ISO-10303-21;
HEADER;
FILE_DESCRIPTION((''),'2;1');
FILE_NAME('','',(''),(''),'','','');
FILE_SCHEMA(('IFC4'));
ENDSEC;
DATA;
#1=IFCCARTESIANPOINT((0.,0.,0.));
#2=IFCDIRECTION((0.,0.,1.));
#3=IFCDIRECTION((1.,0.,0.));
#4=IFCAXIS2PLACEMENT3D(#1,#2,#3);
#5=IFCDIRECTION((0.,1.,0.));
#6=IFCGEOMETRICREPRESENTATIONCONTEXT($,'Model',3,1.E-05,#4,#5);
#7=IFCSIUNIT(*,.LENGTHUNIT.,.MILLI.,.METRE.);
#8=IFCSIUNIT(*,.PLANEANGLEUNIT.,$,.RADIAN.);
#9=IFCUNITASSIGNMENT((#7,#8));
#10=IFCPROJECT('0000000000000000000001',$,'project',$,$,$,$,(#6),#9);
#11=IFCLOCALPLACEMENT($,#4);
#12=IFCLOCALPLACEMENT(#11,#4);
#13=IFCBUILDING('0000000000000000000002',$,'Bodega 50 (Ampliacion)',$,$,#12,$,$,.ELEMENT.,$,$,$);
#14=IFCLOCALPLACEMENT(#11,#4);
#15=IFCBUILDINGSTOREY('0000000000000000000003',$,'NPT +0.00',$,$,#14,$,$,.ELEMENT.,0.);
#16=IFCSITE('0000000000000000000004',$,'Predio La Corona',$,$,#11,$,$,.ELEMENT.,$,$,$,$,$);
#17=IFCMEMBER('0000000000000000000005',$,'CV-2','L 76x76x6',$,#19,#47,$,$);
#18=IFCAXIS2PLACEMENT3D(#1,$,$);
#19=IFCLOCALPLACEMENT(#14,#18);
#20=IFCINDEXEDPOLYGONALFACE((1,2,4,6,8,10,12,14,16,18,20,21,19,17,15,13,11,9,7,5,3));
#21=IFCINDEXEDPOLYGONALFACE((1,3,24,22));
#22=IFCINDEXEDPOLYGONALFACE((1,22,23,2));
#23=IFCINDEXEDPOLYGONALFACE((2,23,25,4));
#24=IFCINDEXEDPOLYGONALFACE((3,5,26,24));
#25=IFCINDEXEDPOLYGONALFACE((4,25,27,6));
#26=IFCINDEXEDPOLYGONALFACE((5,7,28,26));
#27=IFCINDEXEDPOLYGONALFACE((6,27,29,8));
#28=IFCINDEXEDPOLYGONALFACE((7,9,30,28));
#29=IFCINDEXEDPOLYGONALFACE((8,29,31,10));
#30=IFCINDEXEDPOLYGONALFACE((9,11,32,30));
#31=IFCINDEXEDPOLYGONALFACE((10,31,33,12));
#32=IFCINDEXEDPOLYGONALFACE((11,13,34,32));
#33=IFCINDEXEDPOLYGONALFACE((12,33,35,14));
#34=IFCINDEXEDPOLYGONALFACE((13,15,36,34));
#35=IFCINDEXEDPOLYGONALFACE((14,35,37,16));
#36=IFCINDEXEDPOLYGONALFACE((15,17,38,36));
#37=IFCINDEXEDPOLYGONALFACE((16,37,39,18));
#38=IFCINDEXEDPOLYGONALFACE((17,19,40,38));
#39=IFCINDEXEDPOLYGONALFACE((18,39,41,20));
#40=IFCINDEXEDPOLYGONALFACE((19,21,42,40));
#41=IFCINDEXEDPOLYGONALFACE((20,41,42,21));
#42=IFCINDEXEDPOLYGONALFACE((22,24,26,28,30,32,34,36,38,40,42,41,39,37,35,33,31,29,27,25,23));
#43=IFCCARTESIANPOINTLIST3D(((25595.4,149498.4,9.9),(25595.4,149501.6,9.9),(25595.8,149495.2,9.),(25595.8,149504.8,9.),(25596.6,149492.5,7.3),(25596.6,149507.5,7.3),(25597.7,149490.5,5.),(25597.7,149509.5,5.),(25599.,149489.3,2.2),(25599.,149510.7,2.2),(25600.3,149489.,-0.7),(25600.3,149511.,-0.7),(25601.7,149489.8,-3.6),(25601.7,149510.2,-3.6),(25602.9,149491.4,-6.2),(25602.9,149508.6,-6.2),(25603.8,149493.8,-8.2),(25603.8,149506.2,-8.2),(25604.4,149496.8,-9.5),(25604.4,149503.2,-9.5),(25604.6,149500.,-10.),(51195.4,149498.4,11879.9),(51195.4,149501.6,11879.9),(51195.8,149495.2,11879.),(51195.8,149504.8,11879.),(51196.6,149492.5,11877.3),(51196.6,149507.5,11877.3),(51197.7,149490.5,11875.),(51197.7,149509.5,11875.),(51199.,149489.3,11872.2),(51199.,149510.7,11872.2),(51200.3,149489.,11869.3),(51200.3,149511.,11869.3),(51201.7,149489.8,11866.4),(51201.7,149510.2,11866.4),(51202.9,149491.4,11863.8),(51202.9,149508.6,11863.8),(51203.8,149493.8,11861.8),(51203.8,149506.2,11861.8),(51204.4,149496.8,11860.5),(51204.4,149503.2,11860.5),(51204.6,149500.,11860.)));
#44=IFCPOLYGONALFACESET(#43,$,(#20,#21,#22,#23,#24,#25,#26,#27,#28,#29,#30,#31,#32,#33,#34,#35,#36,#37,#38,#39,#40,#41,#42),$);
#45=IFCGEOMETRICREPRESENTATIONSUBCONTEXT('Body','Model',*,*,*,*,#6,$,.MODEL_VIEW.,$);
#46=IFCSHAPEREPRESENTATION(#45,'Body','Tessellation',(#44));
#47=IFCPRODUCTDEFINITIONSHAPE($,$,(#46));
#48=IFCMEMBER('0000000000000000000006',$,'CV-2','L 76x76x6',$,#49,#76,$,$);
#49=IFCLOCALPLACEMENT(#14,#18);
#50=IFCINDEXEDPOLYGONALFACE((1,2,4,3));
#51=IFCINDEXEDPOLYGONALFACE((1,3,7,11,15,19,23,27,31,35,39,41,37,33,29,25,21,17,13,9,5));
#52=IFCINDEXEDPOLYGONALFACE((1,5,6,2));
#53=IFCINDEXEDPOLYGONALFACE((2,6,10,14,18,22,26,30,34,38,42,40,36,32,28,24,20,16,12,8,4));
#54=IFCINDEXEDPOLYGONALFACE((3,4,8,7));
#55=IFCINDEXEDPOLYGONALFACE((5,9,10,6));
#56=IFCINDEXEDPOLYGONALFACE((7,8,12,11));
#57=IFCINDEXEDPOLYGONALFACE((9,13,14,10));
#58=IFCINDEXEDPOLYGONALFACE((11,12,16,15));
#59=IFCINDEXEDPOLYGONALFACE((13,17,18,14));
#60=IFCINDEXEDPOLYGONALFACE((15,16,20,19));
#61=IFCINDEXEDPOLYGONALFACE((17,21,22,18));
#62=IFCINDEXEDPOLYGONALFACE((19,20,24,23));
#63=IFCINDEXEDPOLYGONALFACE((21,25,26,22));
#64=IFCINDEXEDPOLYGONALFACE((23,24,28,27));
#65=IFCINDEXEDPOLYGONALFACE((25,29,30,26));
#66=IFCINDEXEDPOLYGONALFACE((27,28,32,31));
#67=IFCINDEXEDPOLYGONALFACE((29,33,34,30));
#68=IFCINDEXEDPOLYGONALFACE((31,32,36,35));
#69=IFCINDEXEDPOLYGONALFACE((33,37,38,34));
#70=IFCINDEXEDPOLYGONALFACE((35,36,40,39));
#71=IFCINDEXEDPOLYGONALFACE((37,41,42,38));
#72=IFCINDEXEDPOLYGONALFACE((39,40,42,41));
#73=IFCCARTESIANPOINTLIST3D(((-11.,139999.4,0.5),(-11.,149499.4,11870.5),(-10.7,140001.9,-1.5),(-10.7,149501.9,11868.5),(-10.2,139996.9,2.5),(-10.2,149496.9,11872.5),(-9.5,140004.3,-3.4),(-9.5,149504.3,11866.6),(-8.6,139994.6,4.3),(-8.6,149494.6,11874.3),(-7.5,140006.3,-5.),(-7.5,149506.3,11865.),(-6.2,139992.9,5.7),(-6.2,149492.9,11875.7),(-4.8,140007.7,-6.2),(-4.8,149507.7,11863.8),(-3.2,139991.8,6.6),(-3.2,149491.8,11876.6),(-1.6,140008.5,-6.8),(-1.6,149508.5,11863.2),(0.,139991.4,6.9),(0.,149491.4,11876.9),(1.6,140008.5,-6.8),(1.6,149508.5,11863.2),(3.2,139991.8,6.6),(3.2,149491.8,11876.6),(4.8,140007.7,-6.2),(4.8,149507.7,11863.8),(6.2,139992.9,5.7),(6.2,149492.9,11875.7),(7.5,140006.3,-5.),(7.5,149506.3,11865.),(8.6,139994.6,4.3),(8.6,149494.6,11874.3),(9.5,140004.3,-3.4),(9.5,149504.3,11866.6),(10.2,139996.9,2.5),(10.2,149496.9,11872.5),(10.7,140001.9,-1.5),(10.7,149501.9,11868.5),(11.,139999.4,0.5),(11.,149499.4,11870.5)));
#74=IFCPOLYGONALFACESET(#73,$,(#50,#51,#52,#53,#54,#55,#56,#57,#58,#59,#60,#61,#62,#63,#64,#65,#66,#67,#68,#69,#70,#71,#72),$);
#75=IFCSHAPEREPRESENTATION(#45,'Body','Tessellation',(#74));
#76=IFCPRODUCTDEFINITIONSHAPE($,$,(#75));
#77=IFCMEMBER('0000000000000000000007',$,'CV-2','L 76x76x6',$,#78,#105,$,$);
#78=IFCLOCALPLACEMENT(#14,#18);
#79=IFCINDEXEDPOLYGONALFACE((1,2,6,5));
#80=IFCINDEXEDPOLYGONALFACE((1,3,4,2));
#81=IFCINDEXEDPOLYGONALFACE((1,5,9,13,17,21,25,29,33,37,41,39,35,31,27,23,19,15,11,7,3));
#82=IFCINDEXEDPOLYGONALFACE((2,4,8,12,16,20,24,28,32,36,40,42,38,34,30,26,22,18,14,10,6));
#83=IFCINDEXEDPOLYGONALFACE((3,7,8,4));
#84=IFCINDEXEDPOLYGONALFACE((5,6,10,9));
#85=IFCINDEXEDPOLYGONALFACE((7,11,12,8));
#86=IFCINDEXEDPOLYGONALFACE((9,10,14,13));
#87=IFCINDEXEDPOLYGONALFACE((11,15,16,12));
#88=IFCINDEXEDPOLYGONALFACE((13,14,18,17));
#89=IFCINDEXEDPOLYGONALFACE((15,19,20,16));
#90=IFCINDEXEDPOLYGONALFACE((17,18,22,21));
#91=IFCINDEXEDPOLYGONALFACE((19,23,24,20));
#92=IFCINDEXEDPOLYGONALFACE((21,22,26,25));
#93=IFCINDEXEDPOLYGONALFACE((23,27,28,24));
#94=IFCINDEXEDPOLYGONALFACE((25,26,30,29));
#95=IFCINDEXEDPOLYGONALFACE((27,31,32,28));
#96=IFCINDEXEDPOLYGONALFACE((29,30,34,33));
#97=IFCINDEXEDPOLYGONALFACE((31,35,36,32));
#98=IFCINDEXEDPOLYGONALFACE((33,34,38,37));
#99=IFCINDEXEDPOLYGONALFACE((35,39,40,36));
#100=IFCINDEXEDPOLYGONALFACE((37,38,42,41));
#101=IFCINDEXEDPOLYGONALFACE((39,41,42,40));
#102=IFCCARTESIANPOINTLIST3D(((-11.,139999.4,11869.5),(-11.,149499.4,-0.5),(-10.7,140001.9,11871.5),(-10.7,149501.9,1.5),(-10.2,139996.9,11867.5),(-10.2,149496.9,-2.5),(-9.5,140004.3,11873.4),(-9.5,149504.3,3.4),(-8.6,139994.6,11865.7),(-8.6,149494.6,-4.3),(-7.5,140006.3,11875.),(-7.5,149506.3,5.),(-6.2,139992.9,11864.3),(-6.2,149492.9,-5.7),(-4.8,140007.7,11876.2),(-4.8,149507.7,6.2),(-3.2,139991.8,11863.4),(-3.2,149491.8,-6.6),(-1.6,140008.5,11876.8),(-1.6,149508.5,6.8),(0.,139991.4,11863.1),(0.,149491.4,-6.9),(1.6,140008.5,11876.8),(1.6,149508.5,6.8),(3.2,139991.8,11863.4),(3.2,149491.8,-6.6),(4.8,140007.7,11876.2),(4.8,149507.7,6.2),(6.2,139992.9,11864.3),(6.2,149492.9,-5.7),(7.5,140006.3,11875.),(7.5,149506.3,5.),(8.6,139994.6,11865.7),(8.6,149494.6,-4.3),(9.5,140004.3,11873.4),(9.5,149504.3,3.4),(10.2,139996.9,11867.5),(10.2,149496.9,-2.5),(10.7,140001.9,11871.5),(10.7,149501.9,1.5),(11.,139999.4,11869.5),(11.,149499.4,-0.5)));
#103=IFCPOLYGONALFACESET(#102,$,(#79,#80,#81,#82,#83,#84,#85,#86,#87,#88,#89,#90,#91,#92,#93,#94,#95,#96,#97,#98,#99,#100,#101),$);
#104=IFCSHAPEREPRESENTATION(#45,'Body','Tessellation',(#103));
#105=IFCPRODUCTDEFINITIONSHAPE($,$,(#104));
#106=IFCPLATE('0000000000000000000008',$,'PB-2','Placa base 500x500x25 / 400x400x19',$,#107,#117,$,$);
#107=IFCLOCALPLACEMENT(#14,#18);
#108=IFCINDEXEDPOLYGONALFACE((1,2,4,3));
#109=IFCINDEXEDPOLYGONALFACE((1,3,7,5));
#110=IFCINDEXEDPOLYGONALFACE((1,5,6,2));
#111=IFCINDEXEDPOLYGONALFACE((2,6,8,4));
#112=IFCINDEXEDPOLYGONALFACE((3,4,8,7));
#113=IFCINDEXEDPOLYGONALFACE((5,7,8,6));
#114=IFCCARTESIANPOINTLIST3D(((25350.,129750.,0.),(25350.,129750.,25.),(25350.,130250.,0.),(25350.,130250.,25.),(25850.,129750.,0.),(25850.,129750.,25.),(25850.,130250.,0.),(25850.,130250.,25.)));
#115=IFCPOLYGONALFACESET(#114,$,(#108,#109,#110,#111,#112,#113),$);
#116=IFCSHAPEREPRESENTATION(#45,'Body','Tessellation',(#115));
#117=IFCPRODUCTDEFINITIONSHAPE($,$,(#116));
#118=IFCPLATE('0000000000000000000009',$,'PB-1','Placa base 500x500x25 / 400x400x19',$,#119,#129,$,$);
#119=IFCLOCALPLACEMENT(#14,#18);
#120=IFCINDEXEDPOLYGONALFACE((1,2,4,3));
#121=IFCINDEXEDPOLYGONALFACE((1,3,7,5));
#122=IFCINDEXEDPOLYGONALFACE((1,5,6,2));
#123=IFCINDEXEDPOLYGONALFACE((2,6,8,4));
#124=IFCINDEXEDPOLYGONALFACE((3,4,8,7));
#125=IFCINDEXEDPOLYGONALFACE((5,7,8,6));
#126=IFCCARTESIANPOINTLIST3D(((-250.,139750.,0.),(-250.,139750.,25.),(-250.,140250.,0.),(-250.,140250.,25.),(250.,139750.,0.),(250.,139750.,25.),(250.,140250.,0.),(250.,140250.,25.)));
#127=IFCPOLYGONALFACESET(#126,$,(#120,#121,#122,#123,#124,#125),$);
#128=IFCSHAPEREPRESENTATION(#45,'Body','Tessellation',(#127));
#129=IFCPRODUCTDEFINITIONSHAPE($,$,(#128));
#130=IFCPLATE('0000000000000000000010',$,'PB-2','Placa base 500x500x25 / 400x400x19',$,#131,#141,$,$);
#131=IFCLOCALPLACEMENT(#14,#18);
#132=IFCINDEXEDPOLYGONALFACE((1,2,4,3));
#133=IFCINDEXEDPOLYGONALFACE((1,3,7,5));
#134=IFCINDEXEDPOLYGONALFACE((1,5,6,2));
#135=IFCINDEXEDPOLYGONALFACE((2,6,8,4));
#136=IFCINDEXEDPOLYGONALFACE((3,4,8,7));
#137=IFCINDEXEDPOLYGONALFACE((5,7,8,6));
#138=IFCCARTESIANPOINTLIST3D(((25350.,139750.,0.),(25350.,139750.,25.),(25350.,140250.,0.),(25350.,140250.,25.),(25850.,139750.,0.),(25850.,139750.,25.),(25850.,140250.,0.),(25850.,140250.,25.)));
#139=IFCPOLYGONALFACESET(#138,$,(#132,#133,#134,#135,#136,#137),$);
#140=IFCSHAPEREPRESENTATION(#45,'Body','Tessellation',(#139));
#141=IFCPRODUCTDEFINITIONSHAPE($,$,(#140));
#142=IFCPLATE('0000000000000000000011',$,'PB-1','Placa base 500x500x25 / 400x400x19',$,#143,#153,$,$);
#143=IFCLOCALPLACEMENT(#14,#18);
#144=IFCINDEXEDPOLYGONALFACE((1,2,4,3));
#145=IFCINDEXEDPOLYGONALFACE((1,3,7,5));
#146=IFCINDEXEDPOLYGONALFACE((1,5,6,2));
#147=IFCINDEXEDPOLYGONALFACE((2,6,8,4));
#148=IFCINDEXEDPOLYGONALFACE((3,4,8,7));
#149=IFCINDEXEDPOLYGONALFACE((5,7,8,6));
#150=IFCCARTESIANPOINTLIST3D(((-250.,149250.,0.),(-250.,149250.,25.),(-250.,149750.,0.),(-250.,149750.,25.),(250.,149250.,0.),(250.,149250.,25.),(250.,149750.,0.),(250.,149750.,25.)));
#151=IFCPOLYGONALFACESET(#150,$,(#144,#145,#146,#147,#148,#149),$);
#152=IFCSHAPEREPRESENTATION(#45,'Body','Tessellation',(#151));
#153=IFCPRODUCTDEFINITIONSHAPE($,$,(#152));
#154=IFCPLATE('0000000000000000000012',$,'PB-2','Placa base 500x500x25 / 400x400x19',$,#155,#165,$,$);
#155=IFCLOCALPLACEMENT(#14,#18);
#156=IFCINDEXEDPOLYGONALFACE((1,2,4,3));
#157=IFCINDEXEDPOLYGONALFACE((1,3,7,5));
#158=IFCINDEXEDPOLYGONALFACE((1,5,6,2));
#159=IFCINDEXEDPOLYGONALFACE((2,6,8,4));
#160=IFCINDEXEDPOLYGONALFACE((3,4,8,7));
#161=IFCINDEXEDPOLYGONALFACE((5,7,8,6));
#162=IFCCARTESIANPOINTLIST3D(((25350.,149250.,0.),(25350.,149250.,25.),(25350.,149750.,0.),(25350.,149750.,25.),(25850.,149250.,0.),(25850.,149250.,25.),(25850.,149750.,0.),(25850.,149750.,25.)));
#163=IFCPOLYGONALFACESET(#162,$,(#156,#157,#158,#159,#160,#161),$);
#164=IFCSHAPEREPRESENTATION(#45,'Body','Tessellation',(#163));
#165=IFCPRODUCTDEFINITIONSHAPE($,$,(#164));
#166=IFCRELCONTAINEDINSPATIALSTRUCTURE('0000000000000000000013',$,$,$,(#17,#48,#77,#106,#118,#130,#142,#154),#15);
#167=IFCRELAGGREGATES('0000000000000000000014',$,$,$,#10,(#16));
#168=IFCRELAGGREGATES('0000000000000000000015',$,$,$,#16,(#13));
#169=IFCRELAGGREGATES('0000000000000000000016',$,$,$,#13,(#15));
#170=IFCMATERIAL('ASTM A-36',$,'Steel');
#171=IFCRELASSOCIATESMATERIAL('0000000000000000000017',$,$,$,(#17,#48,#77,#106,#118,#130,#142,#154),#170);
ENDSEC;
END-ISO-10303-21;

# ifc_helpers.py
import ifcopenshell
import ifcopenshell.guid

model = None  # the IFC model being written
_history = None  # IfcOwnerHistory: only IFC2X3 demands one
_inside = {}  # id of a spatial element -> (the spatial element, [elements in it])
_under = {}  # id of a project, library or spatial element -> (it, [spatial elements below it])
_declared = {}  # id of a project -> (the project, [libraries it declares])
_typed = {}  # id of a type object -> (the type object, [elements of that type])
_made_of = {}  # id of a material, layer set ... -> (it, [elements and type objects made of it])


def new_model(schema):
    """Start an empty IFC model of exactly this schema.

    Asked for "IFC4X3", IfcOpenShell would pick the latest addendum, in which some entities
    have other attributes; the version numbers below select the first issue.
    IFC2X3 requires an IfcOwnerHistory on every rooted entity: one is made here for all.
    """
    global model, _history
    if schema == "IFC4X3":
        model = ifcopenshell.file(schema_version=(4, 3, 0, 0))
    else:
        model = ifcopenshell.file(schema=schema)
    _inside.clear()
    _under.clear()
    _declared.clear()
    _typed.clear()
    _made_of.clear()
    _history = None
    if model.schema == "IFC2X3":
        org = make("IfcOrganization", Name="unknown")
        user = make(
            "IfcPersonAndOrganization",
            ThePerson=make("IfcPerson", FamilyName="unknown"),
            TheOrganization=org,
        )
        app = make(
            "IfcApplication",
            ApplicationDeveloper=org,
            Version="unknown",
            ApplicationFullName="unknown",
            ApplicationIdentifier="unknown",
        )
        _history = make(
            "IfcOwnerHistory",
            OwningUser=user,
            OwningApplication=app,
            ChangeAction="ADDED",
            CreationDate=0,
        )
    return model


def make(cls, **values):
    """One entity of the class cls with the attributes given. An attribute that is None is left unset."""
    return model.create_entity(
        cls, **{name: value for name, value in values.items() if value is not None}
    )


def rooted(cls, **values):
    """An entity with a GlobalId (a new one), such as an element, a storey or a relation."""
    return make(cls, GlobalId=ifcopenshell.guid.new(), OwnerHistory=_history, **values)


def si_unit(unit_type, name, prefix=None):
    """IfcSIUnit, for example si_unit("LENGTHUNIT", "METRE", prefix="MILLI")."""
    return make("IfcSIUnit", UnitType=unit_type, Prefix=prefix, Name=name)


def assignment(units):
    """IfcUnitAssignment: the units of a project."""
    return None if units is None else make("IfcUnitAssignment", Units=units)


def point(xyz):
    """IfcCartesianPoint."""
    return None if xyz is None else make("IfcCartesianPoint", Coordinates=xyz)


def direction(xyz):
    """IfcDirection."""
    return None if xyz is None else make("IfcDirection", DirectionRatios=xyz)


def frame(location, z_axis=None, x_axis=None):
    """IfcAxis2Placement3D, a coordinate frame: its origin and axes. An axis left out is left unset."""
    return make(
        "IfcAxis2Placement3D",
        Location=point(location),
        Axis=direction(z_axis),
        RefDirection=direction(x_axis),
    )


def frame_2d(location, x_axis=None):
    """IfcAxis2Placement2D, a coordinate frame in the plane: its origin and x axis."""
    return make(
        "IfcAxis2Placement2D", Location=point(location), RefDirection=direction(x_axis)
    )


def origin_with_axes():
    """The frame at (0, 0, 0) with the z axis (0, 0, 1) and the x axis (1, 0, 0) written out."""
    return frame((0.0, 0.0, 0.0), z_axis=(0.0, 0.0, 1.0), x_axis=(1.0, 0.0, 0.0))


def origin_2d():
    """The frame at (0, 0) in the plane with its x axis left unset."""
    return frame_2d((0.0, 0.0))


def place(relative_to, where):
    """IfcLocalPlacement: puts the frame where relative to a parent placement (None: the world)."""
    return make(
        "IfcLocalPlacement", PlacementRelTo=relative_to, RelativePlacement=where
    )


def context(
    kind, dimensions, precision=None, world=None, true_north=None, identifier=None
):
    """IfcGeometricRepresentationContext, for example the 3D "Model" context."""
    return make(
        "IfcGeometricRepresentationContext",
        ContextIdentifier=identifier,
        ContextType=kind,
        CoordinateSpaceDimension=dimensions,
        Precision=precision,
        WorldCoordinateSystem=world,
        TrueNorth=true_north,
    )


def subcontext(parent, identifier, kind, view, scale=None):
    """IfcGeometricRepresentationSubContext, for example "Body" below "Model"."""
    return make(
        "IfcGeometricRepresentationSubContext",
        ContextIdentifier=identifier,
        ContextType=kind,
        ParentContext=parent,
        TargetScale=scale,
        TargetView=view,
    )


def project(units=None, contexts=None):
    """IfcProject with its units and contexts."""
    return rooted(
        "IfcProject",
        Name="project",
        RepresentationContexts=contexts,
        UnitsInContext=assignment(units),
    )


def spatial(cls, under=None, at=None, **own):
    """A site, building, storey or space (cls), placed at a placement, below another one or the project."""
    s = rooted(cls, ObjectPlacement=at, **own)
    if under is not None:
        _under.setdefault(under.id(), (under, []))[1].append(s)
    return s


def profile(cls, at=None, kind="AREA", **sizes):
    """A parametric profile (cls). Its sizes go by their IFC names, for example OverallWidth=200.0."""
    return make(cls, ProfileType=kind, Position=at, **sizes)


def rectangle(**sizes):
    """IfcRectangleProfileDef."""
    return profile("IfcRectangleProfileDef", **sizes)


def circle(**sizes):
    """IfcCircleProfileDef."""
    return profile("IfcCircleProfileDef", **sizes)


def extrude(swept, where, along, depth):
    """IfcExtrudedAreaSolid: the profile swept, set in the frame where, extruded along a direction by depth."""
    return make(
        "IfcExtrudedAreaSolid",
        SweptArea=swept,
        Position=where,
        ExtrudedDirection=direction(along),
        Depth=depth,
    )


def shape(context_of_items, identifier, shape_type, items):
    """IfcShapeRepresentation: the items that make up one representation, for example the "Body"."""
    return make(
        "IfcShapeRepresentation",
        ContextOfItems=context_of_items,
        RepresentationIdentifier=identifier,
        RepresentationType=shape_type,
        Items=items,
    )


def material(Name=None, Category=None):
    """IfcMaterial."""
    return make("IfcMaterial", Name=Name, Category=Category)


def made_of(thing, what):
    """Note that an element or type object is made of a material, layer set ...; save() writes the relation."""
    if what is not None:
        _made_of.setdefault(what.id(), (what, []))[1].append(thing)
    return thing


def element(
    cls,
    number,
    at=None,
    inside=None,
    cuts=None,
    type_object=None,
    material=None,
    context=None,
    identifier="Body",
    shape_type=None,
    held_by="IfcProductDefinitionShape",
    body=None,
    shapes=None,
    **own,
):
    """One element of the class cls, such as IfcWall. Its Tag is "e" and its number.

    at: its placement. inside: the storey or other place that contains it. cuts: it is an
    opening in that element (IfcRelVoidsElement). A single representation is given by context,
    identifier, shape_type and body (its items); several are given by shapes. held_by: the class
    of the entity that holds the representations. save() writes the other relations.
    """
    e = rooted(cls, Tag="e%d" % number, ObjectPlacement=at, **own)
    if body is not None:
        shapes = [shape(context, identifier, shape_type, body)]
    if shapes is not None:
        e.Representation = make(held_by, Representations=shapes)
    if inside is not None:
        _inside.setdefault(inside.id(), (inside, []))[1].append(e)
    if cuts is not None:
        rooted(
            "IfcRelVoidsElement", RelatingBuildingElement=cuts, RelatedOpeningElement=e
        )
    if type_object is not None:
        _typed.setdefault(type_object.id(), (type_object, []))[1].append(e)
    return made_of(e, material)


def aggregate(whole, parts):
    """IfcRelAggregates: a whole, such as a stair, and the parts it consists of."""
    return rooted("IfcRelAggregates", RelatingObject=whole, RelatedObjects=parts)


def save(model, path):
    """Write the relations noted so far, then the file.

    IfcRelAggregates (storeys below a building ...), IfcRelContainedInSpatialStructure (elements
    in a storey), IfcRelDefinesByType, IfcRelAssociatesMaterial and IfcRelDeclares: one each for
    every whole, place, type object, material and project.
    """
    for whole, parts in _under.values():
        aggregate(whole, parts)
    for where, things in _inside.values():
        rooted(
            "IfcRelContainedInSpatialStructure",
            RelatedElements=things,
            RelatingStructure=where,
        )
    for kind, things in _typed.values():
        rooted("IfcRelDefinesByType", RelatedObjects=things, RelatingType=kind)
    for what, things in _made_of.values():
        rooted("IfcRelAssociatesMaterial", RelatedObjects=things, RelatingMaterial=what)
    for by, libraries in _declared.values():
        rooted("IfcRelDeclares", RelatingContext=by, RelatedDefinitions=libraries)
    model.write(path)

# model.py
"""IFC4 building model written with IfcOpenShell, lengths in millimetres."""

from ifc_helpers import new_model, si_unit, direction, frame, origin_with_axes, origin_2d, place, context, subcontext, project, spatial, rectangle, circle, extrude, material, element, save


model = new_model("IFC4")

# Units and contexts
model_context = context("Model", 3, precision=1e-05, world=origin_with_axes(), true_north=direction((0.0, 1.0, 0.0)))
body_context = subcontext(model_context, "Body", "Model", "MODEL_VIEW")
ifc_project = project(units=[si_unit("LENGTHUNIT", "METRE", prefix="MILLI"), si_unit("PLANEANGLEUNIT", "RADIAN")], contexts=[model_context])

# Site, building, storey
site_placement = place(None, origin_with_axes())
site = spatial("IfcSite", under=ifc_project, at=site_placement, Name="Predio La Corona", CompositionType="ELEMENT")
building_placement = place(site_placement, origin_with_axes())
building = spatial("IfcBuilding", under=site, at=building_placement, Name="Bodega 50 (Ampliacion)", CompositionType="ELEMENT")
storey_placement = place(site_placement, origin_with_axes())
storey = spatial("IfcBuildingStorey", under=building, at=storey_placement, Name="NPT +0.00", CompositionType="ELEMENT", Elevation=0.0)

# Shared definitions
ifc_material = material(Name="ASTM A-36", Category="Steel")

# Members
for number, where, z_axis, x_axis, name in (
    (1, (25600.0, 149500.0, 0.0), (0.907222, 0.0, 0.420653), (0.420653, 0.0, -0.907222), "CV-2"),
):
    element("IfcMember", number, at=place(storey_placement, frame(where, z_axis=z_axis, x_axis=x_axis)), inside=storey, material=ifc_material, Name=name, Description="L 76x76x6", context=body_context, shape_type="SweptSolid", body=[
        extrude(circle(Radius=11.0, at=origin_2d()), origin_with_axes(), (0.0, 0.0, 1.0), 28218.0),
    ])
for number, where, z_axis, x_axis, name in (
    (2, (0.0, 140000.0, 0.0), (0.0, 0.624855, 0.78074), (0.0, -0.78074, 0.624855), "CV-2"),
    (3, (0.0, 149500.0, 0.0), (0.0, -0.624855, 0.78074), (0.0, -0.78074, -0.624855), "CV-2"),
):
    element("IfcMember", number, at=place(storey_placement, frame(where, z_axis=z_axis, x_axis=x_axis)), inside=storey, material=ifc_material, Name=name, Description="L 76x76x6", context=body_context, shape_type="SweptSolid", body=[
        extrude(circle(Radius=11.0, at=origin_2d()), origin_with_axes(), (0.0, 0.0, 1.0), 15203.5),
    ])

# Plates
for number, where, z_axis, x_axis, name in (
    (4, (25600.0, 130000.0, 0.0), (0.0, 0.0, 1.0), (1.0, 0.0, 0.0), "PB-2"),
    (5, (0.0, 140000.0, 0.0), (0.0, 0.0, 1.0), (1.0, 0.0, 0.0), "PB-1"),
    (6, (25600.0, 140000.0, 0.0), (0.0, 0.0, 1.0), (1.0, 0.0, 0.0), "PB-2"),
    (7, (0.0, 149500.0, 0.0), (0.0, 0.0, 1.0), (1.0, 0.0, 0.0), "PB-1"),
    (8, (25600.0, 149500.0, 0.0), (0.0, 0.0, 1.0), (1.0, 0.0, 0.0), "PB-2"),
):
    element("IfcPlate", number, at=place(storey_placement, frame(where, z_axis=z_axis, x_axis=x_axis)), inside=storey, material=ifc_material, Name=name, Description="Placa base 500x500x25 / 400x400x19", context=body_context, shape_type="SweptSolid", body=[
        extrude(rectangle(XDim=500.0, YDim=500.0, at=origin_2d()), origin_with_axes(), (0.0, 0.0, 1.0), 25.0),
    ])

save(model, "model.ifc")
